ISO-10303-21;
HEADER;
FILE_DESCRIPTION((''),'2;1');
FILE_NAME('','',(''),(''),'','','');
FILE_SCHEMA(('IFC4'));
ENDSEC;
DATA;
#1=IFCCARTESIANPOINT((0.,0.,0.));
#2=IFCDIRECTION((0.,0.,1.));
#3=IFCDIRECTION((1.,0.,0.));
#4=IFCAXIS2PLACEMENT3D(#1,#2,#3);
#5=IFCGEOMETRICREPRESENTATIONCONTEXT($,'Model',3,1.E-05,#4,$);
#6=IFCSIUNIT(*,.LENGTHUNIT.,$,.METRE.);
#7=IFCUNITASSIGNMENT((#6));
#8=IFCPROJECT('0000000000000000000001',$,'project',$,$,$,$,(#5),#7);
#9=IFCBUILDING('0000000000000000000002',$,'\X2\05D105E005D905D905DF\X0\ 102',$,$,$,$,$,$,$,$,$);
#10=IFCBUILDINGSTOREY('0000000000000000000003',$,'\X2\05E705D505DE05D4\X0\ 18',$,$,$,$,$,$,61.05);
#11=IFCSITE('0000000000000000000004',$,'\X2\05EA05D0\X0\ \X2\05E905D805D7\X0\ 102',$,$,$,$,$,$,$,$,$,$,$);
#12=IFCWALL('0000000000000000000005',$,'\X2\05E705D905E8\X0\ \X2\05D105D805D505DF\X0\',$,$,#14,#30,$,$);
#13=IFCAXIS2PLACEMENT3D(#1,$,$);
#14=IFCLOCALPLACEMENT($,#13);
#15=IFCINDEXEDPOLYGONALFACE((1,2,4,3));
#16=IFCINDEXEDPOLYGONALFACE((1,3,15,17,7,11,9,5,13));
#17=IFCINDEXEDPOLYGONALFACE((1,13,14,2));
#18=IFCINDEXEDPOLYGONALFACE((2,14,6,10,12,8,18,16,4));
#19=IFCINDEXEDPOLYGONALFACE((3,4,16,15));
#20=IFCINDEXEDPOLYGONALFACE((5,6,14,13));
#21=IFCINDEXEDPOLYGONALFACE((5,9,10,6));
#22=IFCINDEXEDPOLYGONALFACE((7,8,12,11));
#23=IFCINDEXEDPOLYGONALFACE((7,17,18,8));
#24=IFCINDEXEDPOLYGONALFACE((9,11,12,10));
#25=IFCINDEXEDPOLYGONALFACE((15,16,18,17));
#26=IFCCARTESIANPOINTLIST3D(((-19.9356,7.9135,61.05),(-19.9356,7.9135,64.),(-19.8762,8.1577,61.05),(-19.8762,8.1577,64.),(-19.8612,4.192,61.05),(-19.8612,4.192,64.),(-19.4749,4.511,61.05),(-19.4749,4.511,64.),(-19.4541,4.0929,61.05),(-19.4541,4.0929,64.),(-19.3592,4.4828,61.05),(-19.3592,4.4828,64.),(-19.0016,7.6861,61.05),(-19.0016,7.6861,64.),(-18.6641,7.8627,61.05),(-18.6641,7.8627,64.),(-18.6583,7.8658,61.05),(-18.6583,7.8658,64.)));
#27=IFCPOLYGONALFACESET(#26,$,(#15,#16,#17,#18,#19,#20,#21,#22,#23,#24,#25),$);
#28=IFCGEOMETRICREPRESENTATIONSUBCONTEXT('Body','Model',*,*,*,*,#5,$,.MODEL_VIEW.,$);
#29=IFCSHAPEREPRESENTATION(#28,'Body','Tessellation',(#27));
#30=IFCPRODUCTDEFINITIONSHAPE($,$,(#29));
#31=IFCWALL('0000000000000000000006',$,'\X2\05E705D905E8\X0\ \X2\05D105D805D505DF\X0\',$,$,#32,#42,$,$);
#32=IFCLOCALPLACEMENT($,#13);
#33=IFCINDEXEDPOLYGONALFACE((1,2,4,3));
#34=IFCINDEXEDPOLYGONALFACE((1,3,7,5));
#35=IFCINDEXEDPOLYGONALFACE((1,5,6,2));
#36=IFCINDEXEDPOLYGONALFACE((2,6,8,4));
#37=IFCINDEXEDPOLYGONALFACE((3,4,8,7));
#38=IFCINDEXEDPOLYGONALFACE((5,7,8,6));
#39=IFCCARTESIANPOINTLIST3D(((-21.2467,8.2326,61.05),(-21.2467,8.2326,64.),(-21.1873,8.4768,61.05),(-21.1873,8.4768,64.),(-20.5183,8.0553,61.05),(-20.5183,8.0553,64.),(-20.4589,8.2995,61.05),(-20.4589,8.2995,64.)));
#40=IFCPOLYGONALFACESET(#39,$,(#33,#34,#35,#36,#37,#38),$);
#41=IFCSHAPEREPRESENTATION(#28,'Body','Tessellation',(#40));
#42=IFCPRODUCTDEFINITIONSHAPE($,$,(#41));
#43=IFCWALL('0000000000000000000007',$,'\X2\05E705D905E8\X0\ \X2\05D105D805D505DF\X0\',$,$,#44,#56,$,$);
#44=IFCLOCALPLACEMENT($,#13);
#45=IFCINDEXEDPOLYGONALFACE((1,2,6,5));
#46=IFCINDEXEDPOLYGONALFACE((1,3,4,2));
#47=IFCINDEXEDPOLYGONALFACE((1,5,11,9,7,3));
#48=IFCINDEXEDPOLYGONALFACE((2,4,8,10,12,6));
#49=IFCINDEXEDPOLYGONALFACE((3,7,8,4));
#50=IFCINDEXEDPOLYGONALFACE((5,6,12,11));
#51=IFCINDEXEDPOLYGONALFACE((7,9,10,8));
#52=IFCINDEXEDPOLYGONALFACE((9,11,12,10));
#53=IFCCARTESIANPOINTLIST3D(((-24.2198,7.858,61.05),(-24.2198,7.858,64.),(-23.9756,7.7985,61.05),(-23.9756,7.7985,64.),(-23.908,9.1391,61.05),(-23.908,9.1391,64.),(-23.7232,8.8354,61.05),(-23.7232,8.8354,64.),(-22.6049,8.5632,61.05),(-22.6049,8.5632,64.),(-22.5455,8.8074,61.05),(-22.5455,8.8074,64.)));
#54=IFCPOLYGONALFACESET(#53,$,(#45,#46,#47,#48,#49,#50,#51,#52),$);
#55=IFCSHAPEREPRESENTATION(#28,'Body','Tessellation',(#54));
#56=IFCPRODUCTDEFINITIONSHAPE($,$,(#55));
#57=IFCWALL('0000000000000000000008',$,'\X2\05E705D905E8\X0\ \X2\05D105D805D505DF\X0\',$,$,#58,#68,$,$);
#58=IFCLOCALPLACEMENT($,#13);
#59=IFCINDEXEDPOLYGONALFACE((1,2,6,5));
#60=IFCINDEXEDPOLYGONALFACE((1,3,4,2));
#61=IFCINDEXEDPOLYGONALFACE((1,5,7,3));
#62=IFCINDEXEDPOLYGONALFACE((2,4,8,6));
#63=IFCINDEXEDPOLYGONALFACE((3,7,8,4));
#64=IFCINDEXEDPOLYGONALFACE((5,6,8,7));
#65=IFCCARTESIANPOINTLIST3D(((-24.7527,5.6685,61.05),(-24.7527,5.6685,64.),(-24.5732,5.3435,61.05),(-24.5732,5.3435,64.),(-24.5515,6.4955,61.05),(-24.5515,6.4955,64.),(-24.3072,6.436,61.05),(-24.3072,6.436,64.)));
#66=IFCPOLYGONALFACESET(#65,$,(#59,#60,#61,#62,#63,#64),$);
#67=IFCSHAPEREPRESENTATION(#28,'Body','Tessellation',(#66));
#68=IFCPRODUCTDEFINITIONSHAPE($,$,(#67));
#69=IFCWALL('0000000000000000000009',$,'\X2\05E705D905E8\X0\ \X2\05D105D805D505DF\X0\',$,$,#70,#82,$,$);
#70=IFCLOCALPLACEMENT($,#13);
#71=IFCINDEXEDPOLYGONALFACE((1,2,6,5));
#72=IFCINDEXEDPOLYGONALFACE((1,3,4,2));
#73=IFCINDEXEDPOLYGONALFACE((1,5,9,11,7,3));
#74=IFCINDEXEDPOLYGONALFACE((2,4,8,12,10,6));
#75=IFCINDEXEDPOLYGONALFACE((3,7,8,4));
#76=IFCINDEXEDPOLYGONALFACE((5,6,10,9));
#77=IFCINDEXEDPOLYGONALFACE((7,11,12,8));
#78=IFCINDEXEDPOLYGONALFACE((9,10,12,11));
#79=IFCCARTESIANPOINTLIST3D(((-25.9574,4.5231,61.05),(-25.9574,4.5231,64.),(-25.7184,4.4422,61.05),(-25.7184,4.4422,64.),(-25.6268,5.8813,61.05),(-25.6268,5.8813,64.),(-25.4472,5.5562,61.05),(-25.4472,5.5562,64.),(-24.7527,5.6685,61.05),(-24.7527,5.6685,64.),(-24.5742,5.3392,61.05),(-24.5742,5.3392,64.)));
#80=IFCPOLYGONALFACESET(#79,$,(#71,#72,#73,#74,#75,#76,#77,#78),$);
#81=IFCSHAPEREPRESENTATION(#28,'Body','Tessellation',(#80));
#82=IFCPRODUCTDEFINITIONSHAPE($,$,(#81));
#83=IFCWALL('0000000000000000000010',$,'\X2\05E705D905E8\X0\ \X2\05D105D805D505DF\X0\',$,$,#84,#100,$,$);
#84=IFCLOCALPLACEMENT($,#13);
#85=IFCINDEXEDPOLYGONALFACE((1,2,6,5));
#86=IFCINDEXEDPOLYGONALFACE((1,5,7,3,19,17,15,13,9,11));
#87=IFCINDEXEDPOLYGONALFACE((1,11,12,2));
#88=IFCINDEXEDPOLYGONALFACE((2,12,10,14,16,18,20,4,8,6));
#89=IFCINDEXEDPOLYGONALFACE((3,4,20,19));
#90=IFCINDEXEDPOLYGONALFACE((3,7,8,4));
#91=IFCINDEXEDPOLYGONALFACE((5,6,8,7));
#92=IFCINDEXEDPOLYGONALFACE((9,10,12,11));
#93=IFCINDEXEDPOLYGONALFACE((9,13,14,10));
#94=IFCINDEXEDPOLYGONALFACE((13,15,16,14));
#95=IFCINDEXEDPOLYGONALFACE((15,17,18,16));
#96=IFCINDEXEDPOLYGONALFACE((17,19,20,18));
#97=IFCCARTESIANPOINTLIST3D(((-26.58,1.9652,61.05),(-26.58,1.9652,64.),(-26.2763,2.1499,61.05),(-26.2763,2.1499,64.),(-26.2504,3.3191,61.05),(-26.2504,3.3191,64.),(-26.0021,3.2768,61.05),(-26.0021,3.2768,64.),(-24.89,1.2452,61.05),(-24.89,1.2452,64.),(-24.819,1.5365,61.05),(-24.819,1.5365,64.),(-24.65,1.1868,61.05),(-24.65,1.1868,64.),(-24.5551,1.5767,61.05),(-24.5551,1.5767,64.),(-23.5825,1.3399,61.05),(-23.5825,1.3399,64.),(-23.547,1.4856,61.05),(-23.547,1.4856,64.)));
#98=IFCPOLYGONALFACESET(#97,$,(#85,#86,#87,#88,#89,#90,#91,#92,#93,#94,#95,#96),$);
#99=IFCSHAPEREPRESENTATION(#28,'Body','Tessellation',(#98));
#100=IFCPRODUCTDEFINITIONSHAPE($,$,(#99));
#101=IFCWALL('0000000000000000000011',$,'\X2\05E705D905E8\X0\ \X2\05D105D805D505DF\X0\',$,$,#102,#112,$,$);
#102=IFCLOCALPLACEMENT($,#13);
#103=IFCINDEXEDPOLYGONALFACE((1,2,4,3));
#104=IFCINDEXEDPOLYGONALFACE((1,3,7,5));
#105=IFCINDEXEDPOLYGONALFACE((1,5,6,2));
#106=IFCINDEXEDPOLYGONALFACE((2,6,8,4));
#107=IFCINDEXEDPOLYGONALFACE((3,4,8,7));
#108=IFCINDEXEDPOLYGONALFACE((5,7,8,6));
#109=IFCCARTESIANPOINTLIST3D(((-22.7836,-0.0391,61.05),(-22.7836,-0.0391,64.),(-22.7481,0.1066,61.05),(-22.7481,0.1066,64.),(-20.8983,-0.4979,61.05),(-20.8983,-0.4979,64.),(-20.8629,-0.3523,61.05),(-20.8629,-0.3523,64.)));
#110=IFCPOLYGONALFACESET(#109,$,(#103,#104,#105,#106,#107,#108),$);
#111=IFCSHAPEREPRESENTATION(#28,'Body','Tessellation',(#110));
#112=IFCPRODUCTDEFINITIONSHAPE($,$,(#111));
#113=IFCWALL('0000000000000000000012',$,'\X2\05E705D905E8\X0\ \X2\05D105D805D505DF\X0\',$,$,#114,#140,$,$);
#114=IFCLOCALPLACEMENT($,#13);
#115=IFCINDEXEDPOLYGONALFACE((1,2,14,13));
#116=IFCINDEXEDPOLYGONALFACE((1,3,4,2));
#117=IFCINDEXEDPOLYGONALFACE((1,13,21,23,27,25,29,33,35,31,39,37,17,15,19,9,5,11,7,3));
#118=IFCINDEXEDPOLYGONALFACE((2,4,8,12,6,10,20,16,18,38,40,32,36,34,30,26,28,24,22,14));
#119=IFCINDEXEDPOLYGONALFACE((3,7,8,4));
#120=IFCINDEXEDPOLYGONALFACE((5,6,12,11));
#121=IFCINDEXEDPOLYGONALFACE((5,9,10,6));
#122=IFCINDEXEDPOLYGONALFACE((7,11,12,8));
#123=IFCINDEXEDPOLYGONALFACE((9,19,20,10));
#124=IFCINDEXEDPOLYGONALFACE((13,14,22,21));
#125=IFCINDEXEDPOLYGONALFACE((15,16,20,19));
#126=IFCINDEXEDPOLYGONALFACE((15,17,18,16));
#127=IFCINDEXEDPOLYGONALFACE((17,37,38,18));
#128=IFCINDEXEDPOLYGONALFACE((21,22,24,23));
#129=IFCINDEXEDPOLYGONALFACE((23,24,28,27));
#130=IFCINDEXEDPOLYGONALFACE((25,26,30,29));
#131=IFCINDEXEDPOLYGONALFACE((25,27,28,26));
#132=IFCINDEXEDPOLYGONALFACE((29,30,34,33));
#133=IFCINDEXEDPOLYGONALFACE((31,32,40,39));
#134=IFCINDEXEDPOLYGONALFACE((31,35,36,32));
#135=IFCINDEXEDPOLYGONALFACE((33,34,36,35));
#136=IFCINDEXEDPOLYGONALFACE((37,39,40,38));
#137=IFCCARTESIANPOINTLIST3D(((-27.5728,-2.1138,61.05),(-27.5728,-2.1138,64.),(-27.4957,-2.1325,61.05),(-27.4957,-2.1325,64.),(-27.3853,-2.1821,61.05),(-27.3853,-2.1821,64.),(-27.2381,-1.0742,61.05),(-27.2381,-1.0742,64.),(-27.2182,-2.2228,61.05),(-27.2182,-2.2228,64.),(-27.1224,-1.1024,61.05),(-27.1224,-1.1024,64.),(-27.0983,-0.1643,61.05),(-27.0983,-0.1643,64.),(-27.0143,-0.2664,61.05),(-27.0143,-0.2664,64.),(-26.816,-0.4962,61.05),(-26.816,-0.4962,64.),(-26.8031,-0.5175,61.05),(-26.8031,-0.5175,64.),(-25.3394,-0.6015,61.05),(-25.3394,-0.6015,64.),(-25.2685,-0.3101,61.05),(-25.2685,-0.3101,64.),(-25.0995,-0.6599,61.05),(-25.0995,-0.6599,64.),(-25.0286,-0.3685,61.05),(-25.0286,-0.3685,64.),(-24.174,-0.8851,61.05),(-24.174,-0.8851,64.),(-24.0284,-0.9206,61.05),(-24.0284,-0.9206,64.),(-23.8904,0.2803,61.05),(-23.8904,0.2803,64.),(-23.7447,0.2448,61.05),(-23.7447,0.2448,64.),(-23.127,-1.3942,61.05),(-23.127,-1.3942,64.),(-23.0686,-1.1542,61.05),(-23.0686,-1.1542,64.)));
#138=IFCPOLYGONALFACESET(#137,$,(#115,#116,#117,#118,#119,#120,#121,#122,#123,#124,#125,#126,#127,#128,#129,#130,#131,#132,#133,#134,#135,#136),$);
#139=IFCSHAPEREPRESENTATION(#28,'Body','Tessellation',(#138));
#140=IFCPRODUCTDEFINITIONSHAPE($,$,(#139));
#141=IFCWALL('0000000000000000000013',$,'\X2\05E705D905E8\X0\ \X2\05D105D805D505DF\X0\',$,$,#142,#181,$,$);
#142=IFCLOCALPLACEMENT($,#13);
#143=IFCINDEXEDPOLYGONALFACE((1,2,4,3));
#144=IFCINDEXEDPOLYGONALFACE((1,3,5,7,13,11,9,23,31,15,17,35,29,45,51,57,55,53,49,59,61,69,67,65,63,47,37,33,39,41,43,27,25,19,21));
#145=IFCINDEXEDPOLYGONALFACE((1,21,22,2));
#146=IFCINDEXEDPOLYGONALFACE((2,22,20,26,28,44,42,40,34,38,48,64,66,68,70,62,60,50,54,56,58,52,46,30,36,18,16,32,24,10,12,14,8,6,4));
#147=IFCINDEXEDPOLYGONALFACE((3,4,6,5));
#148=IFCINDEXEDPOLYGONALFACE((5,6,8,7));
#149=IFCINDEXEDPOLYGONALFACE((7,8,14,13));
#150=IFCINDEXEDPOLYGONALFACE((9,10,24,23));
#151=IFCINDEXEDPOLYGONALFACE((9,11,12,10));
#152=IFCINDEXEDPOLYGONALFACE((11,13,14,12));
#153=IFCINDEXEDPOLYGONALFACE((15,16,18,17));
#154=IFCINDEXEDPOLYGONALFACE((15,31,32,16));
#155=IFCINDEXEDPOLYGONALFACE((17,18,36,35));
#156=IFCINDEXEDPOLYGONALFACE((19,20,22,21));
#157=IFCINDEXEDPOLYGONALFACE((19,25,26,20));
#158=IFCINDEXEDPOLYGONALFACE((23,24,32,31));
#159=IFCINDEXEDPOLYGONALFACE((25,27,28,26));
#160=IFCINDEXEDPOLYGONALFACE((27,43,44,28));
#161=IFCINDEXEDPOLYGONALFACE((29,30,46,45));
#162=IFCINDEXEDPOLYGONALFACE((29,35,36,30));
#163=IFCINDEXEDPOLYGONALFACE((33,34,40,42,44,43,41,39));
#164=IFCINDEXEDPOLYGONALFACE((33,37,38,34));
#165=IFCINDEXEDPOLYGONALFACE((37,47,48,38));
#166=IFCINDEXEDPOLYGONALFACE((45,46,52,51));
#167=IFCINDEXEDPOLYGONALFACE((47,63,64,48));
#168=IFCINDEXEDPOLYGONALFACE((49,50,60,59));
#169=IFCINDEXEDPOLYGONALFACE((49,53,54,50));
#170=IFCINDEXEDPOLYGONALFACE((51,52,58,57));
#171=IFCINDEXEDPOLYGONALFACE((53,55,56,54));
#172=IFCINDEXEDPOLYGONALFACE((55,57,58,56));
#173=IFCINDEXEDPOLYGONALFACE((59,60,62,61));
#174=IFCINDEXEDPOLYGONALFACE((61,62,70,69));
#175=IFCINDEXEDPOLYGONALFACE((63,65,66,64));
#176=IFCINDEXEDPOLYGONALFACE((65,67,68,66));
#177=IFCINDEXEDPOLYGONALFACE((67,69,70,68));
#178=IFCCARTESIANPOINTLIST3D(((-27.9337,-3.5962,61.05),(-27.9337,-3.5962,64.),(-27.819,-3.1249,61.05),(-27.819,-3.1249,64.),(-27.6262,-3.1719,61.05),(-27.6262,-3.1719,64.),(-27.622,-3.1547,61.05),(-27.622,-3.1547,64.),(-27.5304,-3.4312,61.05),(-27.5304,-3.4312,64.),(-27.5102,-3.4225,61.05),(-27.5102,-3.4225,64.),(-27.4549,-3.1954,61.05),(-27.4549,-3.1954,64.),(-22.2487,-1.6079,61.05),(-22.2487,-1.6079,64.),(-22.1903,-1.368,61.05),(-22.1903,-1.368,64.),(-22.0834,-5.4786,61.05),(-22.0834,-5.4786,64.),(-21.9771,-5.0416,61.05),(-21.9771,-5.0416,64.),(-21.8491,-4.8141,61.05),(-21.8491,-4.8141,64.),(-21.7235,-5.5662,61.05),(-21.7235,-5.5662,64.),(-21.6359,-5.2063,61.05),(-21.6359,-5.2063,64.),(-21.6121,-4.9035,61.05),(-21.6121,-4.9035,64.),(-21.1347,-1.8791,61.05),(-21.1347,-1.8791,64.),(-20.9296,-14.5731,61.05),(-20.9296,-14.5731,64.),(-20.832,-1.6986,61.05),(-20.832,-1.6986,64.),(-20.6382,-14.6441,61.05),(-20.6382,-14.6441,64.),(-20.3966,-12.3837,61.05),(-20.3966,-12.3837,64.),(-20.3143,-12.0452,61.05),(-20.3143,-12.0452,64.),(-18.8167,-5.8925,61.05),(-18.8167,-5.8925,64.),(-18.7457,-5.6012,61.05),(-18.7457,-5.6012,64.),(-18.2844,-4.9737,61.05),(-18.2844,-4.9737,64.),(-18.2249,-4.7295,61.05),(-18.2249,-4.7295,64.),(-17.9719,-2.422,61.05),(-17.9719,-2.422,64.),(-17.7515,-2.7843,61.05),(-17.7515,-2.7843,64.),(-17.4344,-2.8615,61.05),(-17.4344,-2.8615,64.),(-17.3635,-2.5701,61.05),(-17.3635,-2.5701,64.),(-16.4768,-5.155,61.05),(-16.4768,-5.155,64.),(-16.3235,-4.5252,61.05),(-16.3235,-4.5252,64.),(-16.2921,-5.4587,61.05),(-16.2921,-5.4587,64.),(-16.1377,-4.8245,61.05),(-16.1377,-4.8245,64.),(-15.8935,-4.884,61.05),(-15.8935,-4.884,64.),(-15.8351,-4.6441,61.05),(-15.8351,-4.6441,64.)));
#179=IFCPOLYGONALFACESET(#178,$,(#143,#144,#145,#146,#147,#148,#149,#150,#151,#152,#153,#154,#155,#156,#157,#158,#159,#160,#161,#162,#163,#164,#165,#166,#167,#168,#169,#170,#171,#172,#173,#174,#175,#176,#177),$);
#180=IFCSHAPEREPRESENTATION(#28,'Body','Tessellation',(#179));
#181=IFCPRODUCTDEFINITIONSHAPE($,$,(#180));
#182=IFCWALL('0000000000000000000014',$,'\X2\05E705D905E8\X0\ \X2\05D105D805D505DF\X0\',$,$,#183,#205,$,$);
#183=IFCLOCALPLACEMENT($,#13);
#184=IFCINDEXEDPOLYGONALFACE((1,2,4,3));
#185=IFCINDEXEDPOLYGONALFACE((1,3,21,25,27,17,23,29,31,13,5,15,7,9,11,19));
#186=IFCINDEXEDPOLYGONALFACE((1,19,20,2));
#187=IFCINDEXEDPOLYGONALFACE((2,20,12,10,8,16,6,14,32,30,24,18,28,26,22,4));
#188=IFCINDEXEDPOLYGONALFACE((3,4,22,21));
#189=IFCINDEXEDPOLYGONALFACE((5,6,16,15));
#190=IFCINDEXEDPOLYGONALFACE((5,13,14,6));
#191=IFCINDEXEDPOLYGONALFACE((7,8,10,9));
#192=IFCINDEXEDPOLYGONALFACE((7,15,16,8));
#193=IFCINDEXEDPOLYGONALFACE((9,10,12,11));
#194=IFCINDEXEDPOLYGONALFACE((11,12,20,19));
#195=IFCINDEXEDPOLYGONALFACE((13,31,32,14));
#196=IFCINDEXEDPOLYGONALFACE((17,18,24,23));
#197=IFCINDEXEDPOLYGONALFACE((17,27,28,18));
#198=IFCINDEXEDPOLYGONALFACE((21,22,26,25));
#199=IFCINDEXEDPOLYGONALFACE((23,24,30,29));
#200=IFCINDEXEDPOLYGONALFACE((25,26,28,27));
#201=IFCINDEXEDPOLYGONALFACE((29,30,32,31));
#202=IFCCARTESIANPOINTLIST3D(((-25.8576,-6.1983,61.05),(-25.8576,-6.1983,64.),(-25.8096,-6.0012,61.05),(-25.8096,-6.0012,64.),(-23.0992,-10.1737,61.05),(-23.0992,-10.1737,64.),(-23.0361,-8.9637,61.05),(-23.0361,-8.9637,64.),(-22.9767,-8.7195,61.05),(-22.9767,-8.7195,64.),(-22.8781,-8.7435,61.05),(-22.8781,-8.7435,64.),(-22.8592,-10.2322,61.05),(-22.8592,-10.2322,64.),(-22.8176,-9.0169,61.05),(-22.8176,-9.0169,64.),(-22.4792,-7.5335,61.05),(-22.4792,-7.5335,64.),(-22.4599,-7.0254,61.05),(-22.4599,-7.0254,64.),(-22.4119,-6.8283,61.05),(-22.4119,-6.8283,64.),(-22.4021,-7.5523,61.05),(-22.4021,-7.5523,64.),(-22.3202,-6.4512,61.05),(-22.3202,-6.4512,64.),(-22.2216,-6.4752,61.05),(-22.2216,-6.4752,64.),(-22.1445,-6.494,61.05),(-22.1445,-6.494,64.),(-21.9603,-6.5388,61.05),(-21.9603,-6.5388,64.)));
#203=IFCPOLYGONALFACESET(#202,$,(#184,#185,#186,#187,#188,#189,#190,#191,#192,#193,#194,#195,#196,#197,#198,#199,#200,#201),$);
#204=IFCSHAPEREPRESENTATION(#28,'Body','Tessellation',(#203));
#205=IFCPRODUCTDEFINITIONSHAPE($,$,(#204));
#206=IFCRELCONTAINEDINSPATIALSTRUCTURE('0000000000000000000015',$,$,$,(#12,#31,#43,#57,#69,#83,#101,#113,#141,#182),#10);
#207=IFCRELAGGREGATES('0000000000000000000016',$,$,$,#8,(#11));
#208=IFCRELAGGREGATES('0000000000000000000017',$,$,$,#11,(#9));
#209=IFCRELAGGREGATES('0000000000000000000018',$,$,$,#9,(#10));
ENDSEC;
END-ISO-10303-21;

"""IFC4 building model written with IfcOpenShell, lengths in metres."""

from ifc_helpers import new_model, si_unit, frame, origin_with_axes, context, subcontext, project, spatial, polyline, outline, extrude, element, save


model = new_model("IFC4")

# Units and contexts
model_context = context("Model", 3, precision=1e-05, world=origin_with_axes())
body_context = subcontext(model_context, "Body", "Model", "MODEL_VIEW")
ifc_project = project(units=[si_unit("LENGTHUNIT", "METRE")], contexts=[model_context])

# Site, building, storey
site = spatial("IfcSite", under=ifc_project, Name="תא שטח 102")
building = spatial("IfcBuilding", under=site, Name="בניין 102")
storey = spatial("IfcBuildingStorey", under=building, Name="קומה 18", Elevation=61.05)

# Walls
element("IfcWall", 1, inside=storey, Name="קיר בטון", context=body_context, shape_type="SweptSolid", body=[
    extrude(outline(polyline([(-19.0016, 7.6861), (-19.8612, 4.192), (-19.4541, 4.0929), (-19.3592, 4.4828), (-19.4749, 4.511), (-18.6583, 7.8658), (-18.7159, 7.8344), (-18.6636, 7.8626), (-19.8762, 8.1577), (-19.9356, 7.9135), (-19.0016, 7.6861)])), frame((0.0, 0.0, 61.05)), (0.0, 0.0, 1.0), 2.95),
])
element("IfcWall", 2, inside=storey, Name="קיר בטון", context=body_context, shape_type="SweptSolid", body=[
    extrude(outline(polyline([(-20.4589, 8.2995), (-21.1873, 8.4768), (-21.2467, 8.2326), (-20.5183, 8.0553), (-20.4589, 8.2995)])), frame((0.0, 0.0, 61.05)), (0.0, 0.0, 1.0), 2.95),
])
element("IfcWall", 3, inside=storey, Name="קיר בטון", context=body_context, shape_type="SweptSolid", body=[
    extrude(outline(polyline([(-24.2198, 7.858), (-23.9756, 7.7985), (-23.7232, 8.8354), (-22.6049, 8.5632), (-22.5455, 8.8074), (-23.908, 9.1391), (-24.2198, 7.858)])), frame((0.0, 0.0, 61.05)), (0.0, 0.0, 1.0), 2.95),
])
element("IfcWall", 4, inside=storey, Name="קיר בטון", context=body_context, shape_type="SweptSolid", body=[
    extrude(outline(polyline([(-24.7527, 5.6685), (-24.5732, 5.3435), (-24.3072, 6.436), (-24.5515, 6.4955), (-24.7527, 5.6685)])), frame((0.0, 0.0, 61.05)), (0.0, 0.0, 1.0), 2.95),
])
element("IfcWall", 5, inside=storey, Name="קיר בטון", context=body_context, shape_type="SweptSolid", body=[
    extrude(outline(polyline([(-25.9574, 4.5231), (-25.7184, 4.4422), (-25.4472, 5.5562), (-24.5742, 5.3392), (-24.7527, 5.6685), (-25.6268, 5.8813), (-25.9574, 4.5231)])), frame((0.0, 0.0, 61.05)), (0.0, 0.0, 1.0), 2.95),
])
element("IfcWall", 6, inside=storey, Name="קיר בטון", context=body_context, shape_type="SweptSolid", body=[
    extrude(outline(polyline([(-26.58, 1.9652), (-24.819, 1.5365), (-24.89, 1.2452), (-24.65, 1.1868), (-24.5551, 1.5767), (-23.5825, 1.3399), (-23.547, 1.4856), (-26.2763, 2.1499), (-26.0021, 3.2768), (-26.2504, 3.3191), (-26.58, 1.9652)])), frame((0.0, 0.0, 61.05)), (0.0, 0.0, 1.0), 2.95),
])
element("IfcWall", 7, inside=storey, Name="קיר בטון", context=body_context, shape_type="SweptSolid", body=[
    extrude(outline(polyline([(-22.7836, -0.0391), (-20.8983, -0.4979), (-20.8629, -0.3523), (-22.7481, 0.1066), (-22.7836, -0.0391)])), frame((0.0, 0.0, 61.05)), (0.0, 0.0, 1.0), 2.95),
])
element("IfcWall", 8, inside=storey, Name="קיר בטון", context=body_context, shape_type="SweptSolid", body=[
    extrude(outline(polyline([(-25.3394, -0.6015), (-27.0983, -0.1643), (-27.5728, -2.1138), (-27.4957, -2.1325), (-27.2381, -1.0742), (-27.1224, -1.1024), (-27.3853, -2.1821), (-27.2182, -2.2228), (-26.8031, -0.5175), (-27.0143, -0.2664), (-26.816, -0.4962), (-23.127, -1.3942), (-23.0686, -1.1542), (-24.0284, -0.9206), (-23.7447, 0.2448), (-23.8904, 0.2803), (-24.174, -0.8851), (-25.0995, -0.6599), (-25.0286, -0.3685), (-25.2685, -0.3101), (-25.3394, -0.6015)])), frame((0.0, 0.0, 61.05)), (0.0, 0.0, 1.0), 2.95),
])
element("IfcWall", 9, inside=storey, Name="קיר בטון", context=body_context, shape_type="SweptSolid", body=[
    extrude(outline(polyline([(-21.8491, -4.8141), (-27.5304, -3.4312), (-27.5102, -3.4225), (-27.4549, -3.1954), (-27.622, -3.1547), (-27.6262, -3.1719), (-27.819, -3.1249), (-27.9337, -3.5962), (-21.9771, -5.0416), (-22.0834, -5.4786), (-21.7235, -5.5662), (-21.6359, -5.2063), (-18.8167, -5.8925), (-20.3143, -12.0452), (-20.3966, -12.3837), (-20.9296, -14.5731), (-20.6382, -14.6441), (-18.2844, -4.9737), (-16.2921, -5.4587), (-16.1377, -4.8245), (-15.8935, -4.884), (-15.8351, -4.6441), (-16.3235, -4.5252), (-16.4768, -5.155), (-18.2249, -4.7295), (-17.7515, -2.7843), (-17.4344, -2.8615), (-17.3635, -2.5701), (-17.9719, -2.422), (-18.7457, -5.6012), (-21.6121, -4.9035), (-20.832, -1.6986), (-22.1903, -1.368), (-22.2487, -1.6079), (-21.1347, -1.8791), (-21.8491, -4.8141)])), frame((0.0, 0.0, 61.05)), (0.0, 0.0, 1.0), 2.95),
])
element("IfcWall", 10, inside=storey, Name="קיר בטון", context=body_context, shape_type="SweptSolid", body=[
    extrude(outline(polyline([(-25.8576, -6.1983), (-22.4599, -7.0254), (-22.8781, -8.7435), (-22.9767, -8.7195), (-23.0361, -8.9637), (-22.8176, -9.0169), (-23.0992, -10.1737), (-22.8592, -10.2322), (-21.9603, -6.5388), (-22.1445, -6.494), (-22.4021, -7.5523), (-22.4792, -7.5335), (-22.2216, -6.4752), (-22.3202, -6.4512), (-22.4119, -6.8283), (-25.8096, -6.0012), (-25.8576, -6.1983)])), frame((0.0, 0.0, 61.05)), (0.0, 0.0, 1.0), 2.95),
])

save(model, "model.ifc")
